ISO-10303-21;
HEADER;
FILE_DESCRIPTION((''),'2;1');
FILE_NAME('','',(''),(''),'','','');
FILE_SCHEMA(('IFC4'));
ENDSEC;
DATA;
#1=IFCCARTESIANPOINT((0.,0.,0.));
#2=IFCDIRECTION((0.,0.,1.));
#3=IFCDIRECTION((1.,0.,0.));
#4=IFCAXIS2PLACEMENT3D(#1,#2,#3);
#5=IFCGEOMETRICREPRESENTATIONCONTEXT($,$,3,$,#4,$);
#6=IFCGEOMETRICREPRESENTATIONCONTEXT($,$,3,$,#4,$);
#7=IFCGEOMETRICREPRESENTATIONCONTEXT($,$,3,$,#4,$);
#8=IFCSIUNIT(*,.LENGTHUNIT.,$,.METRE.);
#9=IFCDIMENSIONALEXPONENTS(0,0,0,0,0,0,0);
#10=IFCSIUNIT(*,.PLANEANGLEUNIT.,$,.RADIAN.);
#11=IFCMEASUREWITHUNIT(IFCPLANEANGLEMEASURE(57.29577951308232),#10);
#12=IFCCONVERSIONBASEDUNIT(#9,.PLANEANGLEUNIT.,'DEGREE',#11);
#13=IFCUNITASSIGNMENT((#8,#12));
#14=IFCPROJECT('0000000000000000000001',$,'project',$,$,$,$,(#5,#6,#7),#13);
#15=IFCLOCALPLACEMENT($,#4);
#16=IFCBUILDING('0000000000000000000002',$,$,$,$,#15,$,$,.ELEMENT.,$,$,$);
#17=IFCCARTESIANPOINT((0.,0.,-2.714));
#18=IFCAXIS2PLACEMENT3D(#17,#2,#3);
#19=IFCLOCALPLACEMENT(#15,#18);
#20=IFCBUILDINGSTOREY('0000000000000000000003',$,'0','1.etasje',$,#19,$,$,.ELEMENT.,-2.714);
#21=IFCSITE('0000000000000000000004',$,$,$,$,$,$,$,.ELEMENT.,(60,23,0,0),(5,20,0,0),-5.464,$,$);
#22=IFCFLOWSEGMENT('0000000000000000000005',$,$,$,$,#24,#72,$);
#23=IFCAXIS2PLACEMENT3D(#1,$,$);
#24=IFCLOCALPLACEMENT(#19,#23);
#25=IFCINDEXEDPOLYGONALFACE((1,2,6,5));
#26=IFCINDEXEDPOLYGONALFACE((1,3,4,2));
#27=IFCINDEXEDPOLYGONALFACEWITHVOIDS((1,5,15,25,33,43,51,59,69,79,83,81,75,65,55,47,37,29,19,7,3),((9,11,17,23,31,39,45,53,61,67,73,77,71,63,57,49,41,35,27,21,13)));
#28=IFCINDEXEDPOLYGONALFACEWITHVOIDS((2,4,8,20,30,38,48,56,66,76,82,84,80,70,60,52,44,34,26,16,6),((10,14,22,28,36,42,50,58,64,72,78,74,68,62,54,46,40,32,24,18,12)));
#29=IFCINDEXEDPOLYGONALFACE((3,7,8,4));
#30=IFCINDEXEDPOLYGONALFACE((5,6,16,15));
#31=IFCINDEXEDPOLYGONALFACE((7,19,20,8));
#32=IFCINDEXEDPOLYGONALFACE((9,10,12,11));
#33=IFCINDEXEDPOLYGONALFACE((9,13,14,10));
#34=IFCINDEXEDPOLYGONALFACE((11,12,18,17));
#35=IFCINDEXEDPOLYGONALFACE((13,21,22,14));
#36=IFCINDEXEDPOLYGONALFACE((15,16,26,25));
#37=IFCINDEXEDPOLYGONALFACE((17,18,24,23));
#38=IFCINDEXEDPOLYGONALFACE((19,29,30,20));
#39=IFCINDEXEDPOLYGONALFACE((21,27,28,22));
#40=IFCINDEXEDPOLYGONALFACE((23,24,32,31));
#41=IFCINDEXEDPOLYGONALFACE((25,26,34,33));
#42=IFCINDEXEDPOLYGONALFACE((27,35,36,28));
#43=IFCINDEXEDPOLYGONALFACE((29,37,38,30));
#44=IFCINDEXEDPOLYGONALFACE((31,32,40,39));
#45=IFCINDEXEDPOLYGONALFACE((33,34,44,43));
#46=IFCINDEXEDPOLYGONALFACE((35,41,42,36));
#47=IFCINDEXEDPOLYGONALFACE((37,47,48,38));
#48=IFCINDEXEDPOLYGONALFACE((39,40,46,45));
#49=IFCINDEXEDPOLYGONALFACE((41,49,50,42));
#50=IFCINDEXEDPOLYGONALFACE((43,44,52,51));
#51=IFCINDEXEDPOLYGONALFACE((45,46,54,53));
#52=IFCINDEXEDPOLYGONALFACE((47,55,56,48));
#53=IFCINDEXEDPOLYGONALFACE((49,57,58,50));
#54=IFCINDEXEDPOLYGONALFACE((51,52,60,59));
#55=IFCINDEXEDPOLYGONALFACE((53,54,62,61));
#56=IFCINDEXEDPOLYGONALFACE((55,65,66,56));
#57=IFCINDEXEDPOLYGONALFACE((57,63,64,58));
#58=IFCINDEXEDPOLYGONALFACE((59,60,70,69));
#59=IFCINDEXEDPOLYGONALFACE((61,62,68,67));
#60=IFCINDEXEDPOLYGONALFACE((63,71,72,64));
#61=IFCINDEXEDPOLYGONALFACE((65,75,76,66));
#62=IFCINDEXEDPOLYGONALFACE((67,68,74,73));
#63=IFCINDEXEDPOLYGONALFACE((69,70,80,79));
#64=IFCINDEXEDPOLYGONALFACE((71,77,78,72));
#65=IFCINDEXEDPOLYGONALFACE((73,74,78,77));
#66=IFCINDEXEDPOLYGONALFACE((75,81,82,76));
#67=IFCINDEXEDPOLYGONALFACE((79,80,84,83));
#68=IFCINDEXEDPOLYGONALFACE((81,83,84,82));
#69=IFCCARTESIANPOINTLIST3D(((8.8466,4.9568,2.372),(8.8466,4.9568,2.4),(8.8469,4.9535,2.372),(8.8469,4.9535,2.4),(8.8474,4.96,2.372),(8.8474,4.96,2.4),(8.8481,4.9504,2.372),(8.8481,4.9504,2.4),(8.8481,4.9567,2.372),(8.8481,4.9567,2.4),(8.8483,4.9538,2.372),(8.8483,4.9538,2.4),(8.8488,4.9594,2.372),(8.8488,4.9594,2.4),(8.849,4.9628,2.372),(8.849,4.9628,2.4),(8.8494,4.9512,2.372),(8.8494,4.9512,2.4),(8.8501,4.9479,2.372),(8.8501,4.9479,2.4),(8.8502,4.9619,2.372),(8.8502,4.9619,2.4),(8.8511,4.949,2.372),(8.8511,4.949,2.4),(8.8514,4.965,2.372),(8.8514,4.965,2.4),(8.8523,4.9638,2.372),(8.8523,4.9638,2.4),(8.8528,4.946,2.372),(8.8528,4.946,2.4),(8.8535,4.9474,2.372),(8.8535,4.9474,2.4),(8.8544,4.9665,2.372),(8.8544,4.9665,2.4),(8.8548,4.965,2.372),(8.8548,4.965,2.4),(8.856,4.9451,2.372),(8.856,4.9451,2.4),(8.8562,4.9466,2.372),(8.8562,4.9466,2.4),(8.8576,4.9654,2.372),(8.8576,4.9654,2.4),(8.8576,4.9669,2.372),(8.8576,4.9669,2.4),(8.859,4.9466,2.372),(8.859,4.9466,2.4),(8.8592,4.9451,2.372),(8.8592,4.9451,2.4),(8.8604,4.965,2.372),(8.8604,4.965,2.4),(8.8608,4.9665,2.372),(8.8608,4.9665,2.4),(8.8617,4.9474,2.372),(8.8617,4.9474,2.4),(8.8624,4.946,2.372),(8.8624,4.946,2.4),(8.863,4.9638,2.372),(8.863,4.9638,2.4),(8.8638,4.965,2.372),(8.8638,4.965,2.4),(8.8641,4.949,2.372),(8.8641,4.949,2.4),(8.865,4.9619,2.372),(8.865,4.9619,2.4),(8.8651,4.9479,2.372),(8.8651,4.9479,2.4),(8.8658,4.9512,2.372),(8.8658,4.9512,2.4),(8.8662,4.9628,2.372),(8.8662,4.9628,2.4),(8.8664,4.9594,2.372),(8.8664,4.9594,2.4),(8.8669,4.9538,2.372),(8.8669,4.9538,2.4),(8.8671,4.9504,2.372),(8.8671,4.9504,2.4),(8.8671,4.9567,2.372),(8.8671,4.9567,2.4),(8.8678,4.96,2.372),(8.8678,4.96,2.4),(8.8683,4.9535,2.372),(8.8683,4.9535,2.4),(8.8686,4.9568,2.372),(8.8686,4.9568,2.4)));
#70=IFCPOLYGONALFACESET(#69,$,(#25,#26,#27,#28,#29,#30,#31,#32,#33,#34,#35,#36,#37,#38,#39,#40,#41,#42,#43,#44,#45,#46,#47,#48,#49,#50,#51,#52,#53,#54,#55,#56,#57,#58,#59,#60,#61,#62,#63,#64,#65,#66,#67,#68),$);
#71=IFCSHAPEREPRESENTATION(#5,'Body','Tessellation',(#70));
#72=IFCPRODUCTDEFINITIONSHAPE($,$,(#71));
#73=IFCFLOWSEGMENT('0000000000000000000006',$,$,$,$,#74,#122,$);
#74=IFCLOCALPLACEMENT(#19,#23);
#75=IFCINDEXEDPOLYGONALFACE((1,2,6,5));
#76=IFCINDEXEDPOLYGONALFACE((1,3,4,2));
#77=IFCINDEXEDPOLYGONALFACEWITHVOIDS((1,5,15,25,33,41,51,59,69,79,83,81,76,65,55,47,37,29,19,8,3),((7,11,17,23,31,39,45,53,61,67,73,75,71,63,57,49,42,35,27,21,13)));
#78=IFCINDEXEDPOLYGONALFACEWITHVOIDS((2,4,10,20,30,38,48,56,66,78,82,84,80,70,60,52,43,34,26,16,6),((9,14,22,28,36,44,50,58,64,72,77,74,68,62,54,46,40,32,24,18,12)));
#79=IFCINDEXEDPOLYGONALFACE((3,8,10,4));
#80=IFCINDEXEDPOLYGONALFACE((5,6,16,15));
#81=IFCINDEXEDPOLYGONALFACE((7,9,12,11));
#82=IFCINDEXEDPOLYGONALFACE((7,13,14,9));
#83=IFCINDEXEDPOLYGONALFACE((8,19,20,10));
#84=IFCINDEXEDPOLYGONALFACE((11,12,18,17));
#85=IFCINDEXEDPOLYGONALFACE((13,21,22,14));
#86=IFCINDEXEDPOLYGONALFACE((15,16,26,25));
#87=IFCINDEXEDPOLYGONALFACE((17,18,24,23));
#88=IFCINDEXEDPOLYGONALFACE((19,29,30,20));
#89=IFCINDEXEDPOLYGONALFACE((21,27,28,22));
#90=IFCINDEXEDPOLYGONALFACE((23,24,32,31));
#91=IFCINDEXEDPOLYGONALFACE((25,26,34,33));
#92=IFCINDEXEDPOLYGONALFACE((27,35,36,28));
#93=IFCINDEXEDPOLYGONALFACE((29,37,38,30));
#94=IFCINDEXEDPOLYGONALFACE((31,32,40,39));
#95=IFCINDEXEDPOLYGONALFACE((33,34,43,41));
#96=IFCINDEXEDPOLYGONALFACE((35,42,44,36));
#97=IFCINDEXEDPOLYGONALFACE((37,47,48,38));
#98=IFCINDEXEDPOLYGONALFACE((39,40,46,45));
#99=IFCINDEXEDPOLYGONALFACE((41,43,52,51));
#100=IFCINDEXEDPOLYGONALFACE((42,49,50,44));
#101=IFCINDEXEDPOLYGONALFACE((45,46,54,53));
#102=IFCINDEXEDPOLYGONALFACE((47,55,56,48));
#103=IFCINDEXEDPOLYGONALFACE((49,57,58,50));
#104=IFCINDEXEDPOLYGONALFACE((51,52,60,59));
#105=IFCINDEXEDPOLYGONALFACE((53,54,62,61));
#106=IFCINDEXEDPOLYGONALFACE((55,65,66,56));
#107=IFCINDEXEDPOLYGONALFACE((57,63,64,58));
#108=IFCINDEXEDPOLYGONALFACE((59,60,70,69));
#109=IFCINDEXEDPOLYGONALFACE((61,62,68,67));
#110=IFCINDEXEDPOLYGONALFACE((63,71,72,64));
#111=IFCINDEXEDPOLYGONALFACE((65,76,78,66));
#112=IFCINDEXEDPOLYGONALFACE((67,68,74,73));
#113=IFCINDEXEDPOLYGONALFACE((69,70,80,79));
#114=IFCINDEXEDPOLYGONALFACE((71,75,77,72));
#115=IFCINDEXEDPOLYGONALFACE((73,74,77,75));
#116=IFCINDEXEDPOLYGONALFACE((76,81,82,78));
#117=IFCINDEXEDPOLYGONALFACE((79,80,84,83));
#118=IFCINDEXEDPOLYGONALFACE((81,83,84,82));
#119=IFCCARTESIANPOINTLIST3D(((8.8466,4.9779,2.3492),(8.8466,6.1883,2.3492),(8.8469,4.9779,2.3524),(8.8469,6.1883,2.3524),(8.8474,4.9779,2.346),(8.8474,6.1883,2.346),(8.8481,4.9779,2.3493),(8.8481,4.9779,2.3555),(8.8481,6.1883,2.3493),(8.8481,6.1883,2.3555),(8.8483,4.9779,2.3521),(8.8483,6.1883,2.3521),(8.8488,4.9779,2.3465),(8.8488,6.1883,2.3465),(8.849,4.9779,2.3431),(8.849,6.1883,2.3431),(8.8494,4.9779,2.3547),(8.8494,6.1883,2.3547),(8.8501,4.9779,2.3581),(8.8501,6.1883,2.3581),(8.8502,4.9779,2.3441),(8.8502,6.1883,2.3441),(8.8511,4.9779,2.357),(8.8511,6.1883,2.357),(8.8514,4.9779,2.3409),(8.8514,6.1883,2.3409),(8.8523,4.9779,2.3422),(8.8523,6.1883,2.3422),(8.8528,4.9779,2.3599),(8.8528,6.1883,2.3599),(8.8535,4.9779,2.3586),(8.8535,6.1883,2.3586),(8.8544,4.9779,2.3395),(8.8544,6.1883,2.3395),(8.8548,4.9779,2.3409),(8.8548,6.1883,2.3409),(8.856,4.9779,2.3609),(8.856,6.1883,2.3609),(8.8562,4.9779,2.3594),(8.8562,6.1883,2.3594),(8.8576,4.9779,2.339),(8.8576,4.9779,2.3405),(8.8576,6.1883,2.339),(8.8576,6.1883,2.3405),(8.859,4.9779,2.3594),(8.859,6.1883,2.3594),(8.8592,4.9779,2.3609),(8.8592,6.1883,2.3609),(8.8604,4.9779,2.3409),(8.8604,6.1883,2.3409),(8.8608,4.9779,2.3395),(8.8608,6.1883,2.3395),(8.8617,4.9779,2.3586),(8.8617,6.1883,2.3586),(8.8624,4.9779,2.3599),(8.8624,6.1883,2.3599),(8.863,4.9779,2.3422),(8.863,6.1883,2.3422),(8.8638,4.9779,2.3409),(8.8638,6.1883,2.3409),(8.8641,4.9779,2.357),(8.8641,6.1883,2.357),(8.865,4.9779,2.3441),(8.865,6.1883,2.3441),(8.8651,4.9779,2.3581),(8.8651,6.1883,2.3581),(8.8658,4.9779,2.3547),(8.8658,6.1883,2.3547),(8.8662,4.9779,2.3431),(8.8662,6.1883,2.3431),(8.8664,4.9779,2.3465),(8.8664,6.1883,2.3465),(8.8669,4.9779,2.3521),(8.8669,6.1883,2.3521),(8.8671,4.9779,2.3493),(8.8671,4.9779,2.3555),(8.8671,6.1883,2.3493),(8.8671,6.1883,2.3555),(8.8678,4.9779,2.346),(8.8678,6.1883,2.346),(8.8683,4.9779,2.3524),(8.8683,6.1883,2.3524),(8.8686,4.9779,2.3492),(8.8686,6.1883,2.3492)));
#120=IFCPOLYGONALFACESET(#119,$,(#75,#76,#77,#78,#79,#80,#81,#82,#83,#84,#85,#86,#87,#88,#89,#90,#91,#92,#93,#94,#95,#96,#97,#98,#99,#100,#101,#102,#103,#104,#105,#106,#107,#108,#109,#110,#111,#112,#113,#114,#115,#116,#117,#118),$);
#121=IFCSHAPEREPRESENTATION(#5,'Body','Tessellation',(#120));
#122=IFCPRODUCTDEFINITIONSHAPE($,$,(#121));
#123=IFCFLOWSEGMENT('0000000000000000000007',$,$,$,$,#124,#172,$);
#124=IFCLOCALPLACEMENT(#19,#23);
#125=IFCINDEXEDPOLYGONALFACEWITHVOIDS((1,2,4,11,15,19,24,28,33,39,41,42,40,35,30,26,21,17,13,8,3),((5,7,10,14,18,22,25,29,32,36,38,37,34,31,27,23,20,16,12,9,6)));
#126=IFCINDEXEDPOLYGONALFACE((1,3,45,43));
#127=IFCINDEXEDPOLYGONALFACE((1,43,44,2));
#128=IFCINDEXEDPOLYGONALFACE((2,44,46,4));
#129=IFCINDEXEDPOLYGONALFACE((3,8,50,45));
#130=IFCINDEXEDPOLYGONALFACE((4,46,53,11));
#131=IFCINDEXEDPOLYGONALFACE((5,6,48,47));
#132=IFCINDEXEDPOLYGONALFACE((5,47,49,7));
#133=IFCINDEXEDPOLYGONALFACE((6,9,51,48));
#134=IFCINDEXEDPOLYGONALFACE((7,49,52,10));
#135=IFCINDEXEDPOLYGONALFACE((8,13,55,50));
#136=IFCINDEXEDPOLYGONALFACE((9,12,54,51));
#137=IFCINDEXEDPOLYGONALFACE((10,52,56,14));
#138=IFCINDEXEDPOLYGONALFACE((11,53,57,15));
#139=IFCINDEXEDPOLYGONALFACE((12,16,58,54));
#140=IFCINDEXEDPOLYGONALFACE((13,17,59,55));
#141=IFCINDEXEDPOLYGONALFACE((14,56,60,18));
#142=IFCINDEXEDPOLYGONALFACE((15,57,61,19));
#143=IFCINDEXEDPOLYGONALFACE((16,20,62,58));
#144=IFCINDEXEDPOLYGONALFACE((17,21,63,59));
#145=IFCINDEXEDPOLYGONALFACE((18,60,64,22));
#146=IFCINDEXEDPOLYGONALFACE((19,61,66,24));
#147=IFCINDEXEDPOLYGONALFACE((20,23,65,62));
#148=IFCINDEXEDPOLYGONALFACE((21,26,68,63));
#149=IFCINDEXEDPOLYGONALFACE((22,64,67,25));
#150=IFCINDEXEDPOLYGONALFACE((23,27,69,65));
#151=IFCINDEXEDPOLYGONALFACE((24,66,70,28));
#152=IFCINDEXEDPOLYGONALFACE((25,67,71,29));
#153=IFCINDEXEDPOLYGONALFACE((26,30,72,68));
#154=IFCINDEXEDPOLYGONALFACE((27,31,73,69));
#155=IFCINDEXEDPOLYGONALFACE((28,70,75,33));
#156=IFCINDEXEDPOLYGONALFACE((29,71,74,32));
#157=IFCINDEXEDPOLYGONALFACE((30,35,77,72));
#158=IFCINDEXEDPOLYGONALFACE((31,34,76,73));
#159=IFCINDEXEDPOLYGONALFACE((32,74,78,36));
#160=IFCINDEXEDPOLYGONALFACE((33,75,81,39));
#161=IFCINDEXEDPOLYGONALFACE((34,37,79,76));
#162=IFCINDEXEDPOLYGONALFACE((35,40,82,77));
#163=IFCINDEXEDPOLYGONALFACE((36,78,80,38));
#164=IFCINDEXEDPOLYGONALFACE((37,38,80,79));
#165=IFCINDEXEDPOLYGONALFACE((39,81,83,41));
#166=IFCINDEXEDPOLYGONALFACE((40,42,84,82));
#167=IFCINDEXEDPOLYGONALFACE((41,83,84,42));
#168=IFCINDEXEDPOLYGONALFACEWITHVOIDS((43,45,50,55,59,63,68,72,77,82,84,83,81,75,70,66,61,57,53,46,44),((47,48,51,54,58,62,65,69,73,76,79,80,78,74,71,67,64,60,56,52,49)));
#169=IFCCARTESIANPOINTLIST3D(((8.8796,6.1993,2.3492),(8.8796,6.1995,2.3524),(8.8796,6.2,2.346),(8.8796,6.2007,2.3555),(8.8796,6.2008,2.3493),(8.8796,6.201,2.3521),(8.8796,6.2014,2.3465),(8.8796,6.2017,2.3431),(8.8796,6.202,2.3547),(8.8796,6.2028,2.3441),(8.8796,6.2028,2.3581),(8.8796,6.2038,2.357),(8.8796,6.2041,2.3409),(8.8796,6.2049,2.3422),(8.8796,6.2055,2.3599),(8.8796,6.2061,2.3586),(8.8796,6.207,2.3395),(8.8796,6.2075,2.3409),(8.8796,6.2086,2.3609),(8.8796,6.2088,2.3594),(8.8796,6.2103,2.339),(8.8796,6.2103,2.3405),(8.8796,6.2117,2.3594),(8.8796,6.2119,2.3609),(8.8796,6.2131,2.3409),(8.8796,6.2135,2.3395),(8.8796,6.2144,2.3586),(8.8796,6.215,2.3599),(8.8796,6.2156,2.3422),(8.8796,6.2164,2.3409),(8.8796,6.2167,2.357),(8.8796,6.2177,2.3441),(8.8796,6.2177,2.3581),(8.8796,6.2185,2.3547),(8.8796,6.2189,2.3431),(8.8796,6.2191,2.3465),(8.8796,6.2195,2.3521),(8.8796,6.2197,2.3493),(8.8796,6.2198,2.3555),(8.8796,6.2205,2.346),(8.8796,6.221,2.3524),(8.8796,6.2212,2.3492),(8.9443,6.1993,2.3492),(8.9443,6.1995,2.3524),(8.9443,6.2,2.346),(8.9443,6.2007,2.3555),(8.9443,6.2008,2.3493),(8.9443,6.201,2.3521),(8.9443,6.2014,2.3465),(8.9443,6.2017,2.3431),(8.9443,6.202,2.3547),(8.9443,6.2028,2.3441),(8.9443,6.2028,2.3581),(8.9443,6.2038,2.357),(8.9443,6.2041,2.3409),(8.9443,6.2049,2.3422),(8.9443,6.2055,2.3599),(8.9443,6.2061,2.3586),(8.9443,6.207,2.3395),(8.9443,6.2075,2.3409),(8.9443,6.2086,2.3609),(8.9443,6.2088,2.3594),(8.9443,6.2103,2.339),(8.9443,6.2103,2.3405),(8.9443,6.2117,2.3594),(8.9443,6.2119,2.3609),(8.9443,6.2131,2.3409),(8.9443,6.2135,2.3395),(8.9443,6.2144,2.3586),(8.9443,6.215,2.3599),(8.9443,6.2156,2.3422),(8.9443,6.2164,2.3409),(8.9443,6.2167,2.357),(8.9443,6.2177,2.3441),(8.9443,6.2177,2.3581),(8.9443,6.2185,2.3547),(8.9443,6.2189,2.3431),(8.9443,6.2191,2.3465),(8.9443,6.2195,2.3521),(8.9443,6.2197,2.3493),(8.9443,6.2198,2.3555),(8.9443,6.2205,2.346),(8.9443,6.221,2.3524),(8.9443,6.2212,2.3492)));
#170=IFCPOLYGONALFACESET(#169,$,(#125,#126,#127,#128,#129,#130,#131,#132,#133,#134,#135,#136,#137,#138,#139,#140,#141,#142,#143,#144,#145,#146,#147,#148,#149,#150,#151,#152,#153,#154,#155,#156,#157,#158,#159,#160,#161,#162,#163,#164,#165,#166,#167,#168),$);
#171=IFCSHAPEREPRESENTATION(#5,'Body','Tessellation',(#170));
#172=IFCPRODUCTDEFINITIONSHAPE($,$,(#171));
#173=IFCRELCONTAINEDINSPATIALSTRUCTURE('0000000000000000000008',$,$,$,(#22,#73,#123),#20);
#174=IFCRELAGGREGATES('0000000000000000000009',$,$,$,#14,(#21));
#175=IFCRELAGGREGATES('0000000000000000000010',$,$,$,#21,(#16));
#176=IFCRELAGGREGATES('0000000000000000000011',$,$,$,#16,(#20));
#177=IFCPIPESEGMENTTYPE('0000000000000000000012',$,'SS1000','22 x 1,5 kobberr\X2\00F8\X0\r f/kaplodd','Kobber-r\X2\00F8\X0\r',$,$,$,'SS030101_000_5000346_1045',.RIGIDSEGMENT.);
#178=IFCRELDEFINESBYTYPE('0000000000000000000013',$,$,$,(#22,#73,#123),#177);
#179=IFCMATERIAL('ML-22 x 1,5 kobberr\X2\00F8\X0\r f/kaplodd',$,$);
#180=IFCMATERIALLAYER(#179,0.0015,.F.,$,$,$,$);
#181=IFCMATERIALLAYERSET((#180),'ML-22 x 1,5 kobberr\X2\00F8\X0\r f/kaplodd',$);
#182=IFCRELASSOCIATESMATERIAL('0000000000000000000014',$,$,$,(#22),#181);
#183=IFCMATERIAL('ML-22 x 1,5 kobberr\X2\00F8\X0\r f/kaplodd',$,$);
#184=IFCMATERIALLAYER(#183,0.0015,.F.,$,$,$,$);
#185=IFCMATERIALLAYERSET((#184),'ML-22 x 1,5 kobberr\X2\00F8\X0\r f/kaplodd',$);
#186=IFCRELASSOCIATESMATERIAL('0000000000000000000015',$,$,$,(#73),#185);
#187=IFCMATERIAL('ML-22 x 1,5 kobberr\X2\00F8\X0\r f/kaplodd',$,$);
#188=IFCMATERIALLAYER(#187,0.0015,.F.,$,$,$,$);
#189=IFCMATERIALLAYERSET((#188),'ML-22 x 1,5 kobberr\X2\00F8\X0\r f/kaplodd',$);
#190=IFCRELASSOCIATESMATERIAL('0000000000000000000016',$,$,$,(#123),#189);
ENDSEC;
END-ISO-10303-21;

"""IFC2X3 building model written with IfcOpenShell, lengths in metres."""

from ifc_helpers import new_model, entity, si_unit, converted_unit, frame, origin_with_axes, origin_2d_with_axis, place, context, project, spatial, hollow_circle, extrude, material, layer, layer_set, layer_usage, type_object, element, save


model = new_model("IFC2X3")

# Units and contexts
context_of_model_1 = context(None, 3, world=origin_with_axes())
context_of_model_2 = context(None, 3, world=origin_with_axes())
context_of_model_3 = context(None, 3, world=origin_with_axes())
ifc_project = project(units=[si_unit("LENGTHUNIT", "METRE"), converted_unit("PLANEANGLEUNIT", "DEGREE", entity("IfcPlaneAngleMeasure", 57.29577951308232), si_unit("PLANEANGLEUNIT", "RADIAN"), dimensions=[0, 0, 0, 0, 0, 0, 0])], contexts=[context_of_model_1, context_of_model_2, context_of_model_3])

# Site, building, storey
site = spatial("IfcSite", under=ifc_project, CompositionType="ELEMENT", RefLatitude=(60, 23, 0, 0), RefLongitude=(5, 20, 0, 0), RefElevation=-5.464)
building_placement = place(None, origin_with_axes())
building = spatial("IfcBuilding", under=site, at=building_placement, CompositionType="ELEMENT")
storey_placement = place(building_placement, frame((0.0, 0.0, -2.714), z_axis=(0.0, 0.0, 1.0), x_axis=(1.0, 0.0, 0.0)))
storey = spatial("IfcBuildingStorey", under=building, at=storey_placement, Name="0", Description="1.etasje", CompositionType="ELEMENT", Elevation=-2.714)

# Flow segments
pipe_segment_type_1 = type_object("IfcPipeSegmentType", Name="SS1000", Description="22 x 1,5 kobberrør f/kaplodd", ApplicableOccurrence="Kobber-rør", ElementType="SS030101_000_5000346_1045", PredefinedType="RIGIDSEGMENT")
ifc_material_1 = material(Name="ML-22 x 1,5 kobberrør f/kaplodd")
ifc_layer_1 = layer(ifc_material_1, 0.0015, ventilated=False)
ifc_layer_set_1 = layer_set([ifc_layer_1], Name="ML-22 x 1,5 kobberrør f/kaplodd")
ifc_layer_usage_1 = layer_usage(ifc_layer_set_1, "AXIS2", "POSITIVE", 0.0)
flow_segment_1_placement = place(storey_placement, frame((8.8576, 4.9559, 2.4), z_axis=(0.0, 0.0, -1.0), x_axis=(0.0, 1.0, 0.0)))
element("IfcFlowSegment", 1, at=flow_segment_1_placement, inside=storey, type_object=pipe_segment_type_1, material=ifc_layer_usage_1, context=context_of_model_1, shape_type="SweptSolid", body=[
    extrude(hollow_circle(Radius=0.011, WallThickness=0.0015, at=origin_2d_with_axis()), origin_with_axes(), (0.0, 0.0, 1.0), 0.028),
])
ifc_material_2 = material(Name="ML-22 x 1,5 kobberrør f/kaplodd")
ifc_layer_2 = layer(ifc_material_2, 0.0015, ventilated=False)
ifc_layer_set_2 = layer_set([ifc_layer_2], Name="ML-22 x 1,5 kobberrør f/kaplodd")
ifc_layer_usage_2 = layer_usage(ifc_layer_set_2, "AXIS2", "POSITIVE", 0.0)
flow_segment_2_placement = place(storey_placement, frame((8.8576, 4.9779, 2.35), z_axis=(0.0, 1.0, 0.0), x_axis=(0.0, 0.0, -1.0)))
element("IfcFlowSegment", 2, at=flow_segment_2_placement, inside=storey, type_object=pipe_segment_type_1, material=ifc_layer_usage_2, context=context_of_model_1, shape_type="SweptSolid", body=[
    extrude(hollow_circle(Radius=0.011, WallThickness=0.0015, at=origin_2d_with_axis()), origin_with_axes(), (0.0, 0.0, 1.0), 1.2103),
])
ifc_material_3 = material(Name="ML-22 x 1,5 kobberrør f/kaplodd")
ifc_layer_3 = layer(ifc_material_3, 0.0015, ventilated=False)
ifc_layer_set_3 = layer_set([ifc_layer_3], Name="ML-22 x 1,5 kobberrør f/kaplodd")
ifc_layer_usage_3 = layer_usage(ifc_layer_set_3, "AXIS2", "POSITIVE", 0.0)
flow_segment_3_placement = place(storey_placement, frame((8.8796, 6.2103, 2.35), z_axis=(1.0, 0.0, 0.0), x_axis=(0.0, 0.0, -1.0)))
element("IfcFlowSegment", 3, at=flow_segment_3_placement, inside=storey, type_object=pipe_segment_type_1, material=ifc_layer_usage_3, context=context_of_model_1, shape_type="SweptSolid", body=[
    extrude(hollow_circle(Radius=0.011, WallThickness=0.0015, at=origin_2d_with_axis()), origin_with_axes(), (0.0, 0.0, 1.0), 0.0647),
])

save(model, "model.ifc")
